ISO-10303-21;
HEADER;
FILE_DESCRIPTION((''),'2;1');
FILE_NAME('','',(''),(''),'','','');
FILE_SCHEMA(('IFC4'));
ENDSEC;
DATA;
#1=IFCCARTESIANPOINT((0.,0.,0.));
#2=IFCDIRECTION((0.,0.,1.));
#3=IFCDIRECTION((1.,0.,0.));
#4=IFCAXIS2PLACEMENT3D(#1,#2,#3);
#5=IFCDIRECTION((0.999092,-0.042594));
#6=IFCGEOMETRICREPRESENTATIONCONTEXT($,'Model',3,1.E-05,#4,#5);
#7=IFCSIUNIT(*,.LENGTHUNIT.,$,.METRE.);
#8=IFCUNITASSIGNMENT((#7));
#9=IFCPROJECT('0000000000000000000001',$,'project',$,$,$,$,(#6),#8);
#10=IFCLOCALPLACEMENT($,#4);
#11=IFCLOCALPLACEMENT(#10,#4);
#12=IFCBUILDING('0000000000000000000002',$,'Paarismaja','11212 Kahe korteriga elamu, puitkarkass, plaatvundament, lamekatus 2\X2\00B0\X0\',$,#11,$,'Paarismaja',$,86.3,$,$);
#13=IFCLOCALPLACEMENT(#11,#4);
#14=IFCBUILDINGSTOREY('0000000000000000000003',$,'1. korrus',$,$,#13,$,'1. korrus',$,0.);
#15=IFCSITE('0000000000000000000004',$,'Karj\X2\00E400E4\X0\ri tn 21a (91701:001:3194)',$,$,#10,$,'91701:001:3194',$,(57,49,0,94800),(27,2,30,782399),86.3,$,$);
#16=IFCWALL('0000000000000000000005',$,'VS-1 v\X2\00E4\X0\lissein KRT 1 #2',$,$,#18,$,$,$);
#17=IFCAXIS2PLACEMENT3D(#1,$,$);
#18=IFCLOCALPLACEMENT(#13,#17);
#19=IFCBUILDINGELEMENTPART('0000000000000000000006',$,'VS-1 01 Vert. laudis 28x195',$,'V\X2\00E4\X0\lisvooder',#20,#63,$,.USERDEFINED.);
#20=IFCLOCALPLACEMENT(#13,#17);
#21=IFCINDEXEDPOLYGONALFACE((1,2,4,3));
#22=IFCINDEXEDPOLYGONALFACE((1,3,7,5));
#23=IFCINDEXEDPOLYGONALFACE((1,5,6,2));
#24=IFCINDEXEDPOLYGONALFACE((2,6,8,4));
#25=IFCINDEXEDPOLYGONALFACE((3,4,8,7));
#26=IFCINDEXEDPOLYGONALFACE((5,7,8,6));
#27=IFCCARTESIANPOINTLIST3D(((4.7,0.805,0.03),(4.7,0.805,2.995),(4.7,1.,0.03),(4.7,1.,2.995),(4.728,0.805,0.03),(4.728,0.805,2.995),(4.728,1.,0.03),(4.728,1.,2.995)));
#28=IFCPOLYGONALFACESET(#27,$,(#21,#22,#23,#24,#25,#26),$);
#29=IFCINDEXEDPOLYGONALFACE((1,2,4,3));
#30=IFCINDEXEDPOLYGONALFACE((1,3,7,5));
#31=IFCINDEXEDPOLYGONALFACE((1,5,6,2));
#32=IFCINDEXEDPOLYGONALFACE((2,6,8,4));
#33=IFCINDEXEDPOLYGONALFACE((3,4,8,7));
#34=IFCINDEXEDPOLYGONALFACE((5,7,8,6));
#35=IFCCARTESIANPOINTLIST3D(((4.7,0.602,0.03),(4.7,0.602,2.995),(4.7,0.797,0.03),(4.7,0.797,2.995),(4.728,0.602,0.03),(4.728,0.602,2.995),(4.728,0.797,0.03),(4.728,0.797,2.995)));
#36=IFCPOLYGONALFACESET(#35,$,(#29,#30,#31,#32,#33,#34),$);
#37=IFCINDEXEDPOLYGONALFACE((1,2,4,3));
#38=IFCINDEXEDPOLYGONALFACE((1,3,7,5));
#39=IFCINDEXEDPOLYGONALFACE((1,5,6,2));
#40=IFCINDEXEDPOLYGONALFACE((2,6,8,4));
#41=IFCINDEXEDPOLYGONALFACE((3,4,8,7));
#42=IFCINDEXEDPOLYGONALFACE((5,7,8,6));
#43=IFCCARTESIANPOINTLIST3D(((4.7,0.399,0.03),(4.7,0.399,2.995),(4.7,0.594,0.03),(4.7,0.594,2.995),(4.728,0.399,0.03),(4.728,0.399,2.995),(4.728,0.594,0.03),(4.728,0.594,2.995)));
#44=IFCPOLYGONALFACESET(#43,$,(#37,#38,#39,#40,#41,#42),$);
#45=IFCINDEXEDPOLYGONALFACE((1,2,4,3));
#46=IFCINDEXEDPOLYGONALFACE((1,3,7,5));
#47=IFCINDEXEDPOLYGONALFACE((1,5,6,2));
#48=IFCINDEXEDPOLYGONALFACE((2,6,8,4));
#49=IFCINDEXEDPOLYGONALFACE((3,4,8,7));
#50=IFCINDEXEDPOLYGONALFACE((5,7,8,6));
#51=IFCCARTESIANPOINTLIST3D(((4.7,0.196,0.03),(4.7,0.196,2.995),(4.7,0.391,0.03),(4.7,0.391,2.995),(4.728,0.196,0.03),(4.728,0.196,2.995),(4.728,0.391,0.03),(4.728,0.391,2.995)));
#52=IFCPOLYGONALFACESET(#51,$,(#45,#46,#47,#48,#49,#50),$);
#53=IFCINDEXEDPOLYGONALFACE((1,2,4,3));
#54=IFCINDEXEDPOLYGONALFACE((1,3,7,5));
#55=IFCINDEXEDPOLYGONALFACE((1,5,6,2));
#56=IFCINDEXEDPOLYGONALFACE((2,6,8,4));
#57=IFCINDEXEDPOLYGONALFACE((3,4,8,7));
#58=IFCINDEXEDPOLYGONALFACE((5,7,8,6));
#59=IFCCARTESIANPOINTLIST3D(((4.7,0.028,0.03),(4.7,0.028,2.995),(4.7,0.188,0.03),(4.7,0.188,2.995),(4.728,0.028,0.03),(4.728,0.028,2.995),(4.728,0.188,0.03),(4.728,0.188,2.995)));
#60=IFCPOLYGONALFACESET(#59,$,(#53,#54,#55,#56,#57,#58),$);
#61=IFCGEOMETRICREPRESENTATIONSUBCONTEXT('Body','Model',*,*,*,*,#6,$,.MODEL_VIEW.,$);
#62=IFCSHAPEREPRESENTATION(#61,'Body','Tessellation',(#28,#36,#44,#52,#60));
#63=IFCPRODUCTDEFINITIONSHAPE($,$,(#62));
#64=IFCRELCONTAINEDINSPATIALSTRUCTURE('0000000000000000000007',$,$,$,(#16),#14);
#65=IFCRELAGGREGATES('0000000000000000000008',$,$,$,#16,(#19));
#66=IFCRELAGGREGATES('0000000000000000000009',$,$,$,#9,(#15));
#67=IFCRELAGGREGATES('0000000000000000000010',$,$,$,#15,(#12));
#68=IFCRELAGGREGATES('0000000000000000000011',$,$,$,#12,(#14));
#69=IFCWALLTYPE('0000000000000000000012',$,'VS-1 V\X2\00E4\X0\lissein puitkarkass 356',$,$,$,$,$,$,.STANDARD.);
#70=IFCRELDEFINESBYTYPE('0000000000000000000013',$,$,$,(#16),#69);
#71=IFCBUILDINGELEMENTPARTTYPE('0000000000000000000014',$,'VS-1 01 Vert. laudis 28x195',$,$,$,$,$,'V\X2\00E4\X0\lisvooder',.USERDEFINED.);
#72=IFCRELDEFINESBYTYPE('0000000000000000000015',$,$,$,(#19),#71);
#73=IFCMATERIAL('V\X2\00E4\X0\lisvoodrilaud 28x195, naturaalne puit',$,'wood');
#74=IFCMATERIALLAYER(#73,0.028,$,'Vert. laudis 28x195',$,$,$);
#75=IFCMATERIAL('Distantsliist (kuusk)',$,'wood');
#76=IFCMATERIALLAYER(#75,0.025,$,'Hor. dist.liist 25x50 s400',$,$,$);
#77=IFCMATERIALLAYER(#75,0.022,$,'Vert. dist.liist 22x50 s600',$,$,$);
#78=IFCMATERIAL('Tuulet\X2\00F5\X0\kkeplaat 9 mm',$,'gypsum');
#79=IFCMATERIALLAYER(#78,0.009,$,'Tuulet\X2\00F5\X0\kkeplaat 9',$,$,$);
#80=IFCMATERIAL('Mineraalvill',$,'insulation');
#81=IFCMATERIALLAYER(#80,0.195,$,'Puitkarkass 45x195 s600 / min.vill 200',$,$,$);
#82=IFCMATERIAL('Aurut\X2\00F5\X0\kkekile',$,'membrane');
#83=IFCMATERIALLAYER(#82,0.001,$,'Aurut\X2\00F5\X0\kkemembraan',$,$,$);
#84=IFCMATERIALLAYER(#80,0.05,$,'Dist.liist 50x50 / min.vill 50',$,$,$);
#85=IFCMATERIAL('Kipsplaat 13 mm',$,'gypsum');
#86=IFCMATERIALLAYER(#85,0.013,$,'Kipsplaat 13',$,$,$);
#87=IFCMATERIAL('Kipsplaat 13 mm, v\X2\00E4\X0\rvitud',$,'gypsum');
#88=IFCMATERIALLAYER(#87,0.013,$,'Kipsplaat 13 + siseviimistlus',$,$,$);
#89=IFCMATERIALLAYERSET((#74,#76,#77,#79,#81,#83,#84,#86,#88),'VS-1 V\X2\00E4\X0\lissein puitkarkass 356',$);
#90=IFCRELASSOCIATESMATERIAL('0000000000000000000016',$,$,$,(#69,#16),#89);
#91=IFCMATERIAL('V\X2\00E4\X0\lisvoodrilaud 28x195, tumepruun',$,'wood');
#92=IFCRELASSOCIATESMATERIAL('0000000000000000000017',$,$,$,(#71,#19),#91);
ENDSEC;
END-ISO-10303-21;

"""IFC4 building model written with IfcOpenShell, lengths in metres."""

from ifc_helpers import new_model, si_unit, direction, frame, origin_with_axes, place, context, subcontext, project, spatial, indexed_curve, outline, extrude, material, layer, layer_set, layer_usage, type_object, element, aggregate, save


model = new_model("IFC4")

# Units and contexts
model_context = context("Model", 3, precision=1e-05, world=origin_with_axes(), true_north=direction((0.999092, -0.042594)))
body_context = subcontext(model_context, "Body", "Model", "MODEL_VIEW")
ifc_project = project(units=[si_unit("LENGTHUNIT", "METRE")], contexts=[model_context])

# Site, building, storey
site_placement = place(None, origin_with_axes())
site = spatial("IfcSite", under=ifc_project, at=site_placement, Name="Karjääri tn 21a (91701:001:3194)", LongName="91701:001:3194", RefLatitude=(57, 49, 0, 94800), RefLongitude=(27, 2, 30, 782399), RefElevation=86.3)
building_placement = place(site_placement, origin_with_axes())
building = spatial("IfcBuilding", under=site, at=building_placement, Name="Paarismaja", Description="11212 Kahe korteriga elamu, puitkarkass, plaatvundament, lamekatus 2°", LongName="Paarismaja", ElevationOfRefHeight=86.3)
storey_placement = place(building_placement, origin_with_axes())
storey = spatial("IfcBuildingStorey", under=building, at=storey_placement, Name="1. korrus", LongName="1. korrus", Elevation=0.0)

# Wall
ifc_material_1 = material(Name="Välisvoodrilaud 28x195, naturaalne puit", Category="wood")
ifc_layer_1 = layer(ifc_material_1, 0.028, Name="Vert. laudis 28x195")
ifc_material_2 = material(Name="Distantsliist (kuusk)", Category="wood")
ifc_layer_2 = layer(ifc_material_2, 0.025, Name="Hor. dist.liist 25x50 s400")
ifc_layer_3 = layer(ifc_material_2, 0.022, Name="Vert. dist.liist 22x50 s600")
ifc_material_3 = material(Name="Tuuletõkkeplaat 9 mm", Category="gypsum")
ifc_layer_4 = layer(ifc_material_3, 0.009, Name="Tuuletõkkeplaat 9")
ifc_material_4 = material(Name="Mineraalvill", Category="insulation")
ifc_layer_5 = layer(ifc_material_4, 0.195, Name="Puitkarkass 45x195 s600 / min.vill 200")
ifc_material_5 = material(Name="Aurutõkkekile", Category="membrane")
ifc_layer_6 = layer(ifc_material_5, 0.001, Name="Aurutõkkemembraan")
ifc_layer_7 = layer(ifc_material_4, 0.05, Name="Dist.liist 50x50 / min.vill 50")
ifc_material_6 = material(Name="Kipsplaat 13 mm", Category="gypsum")
ifc_layer_8 = layer(ifc_material_6, 0.013, Name="Kipsplaat 13")
ifc_material_7 = material(Name="Kipsplaat 13 mm, värvitud", Category="gypsum")
ifc_layer_9 = layer(ifc_material_7, 0.013, Name="Kipsplaat 13 + siseviimistlus")
ifc_layer_set_1 = layer_set([ifc_layer_1, ifc_layer_2, ifc_layer_3, ifc_layer_4, ifc_layer_5, ifc_layer_6, ifc_layer_7, ifc_layer_8, ifc_layer_9], Name="VS-1 Välissein puitkarkass 356")
ifc_layer_usage_1 = layer_usage(ifc_layer_set_1, "AXIS2", "POSITIVE", 0.0)
wall_type = type_object("IfcWallType", Name="VS-1 Välissein puitkarkass 356", PredefinedType="STANDARD", material=ifc_layer_set_1)
wall_placement = place(storey_placement, frame((4.7, 1.0, 0.0), z_axis=(0.0, 0.0, 1.0), x_axis=(0.0, -1.0, 0.0)))
wall = element("IfcWall", 1, at=wall_placement, inside=storey, type_object=wall_type, material=ifc_layer_usage_1, Name="VS-1 välissein KRT 1 #2")

# Building element part
ifc_material_8 = material(Name="Välisvoodrilaud 28x195, tumepruun", Category="wood")
building_element_part_type_1 = type_object("IfcBuildingElementPartType", Name="VS-1 01 Vert. laudis 28x195", ElementType="Välisvooder", PredefinedType="USERDEFINED", material=ifc_material_8)
building_element_part_1_placement = place(wall_placement, origin_with_axes())
building_element_part_1 = element("IfcBuildingElementPart", 2, at=building_element_part_1_placement, type_object=building_element_part_type_1, material=ifc_material_8, Name="VS-1 01 Vert. laudis 28x195", ObjectType="Välisvooder", PredefinedType="USERDEFINED", context=body_context, shape_type="SweptSolid", body=[
    extrude(outline(indexed_curve([(0.195, 0.03), (0.0, 0.03), (0.0, 2.995), (0.195, 2.995), (0.195, 0.03)], self_intersect=False)), frame((0.0, 0.028, 0.0), z_axis=(0.0, -1.0, 0.0), x_axis=(1.0, 0.0, 0.0)), (0.0, 0.0, 1.0), 0.028),
    extrude(outline(indexed_curve([(0.398, 0.03), (0.203, 0.03), (0.203, 2.995), (0.398, 2.995), (0.398, 0.03)], self_intersect=False)), frame((0.0, 0.028, 0.0), z_axis=(0.0, -1.0, 0.0), x_axis=(1.0, 0.0, 0.0)), (0.0, 0.0, 1.0), 0.028),
    extrude(outline(indexed_curve([(0.601, 0.03), (0.406, 0.03), (0.406, 2.995), (0.601, 2.995), (0.601, 0.03)], self_intersect=False)), frame((0.0, 0.028, 0.0), z_axis=(0.0, -1.0, 0.0), x_axis=(1.0, 0.0, 0.0)), (0.0, 0.0, 1.0), 0.028),
    extrude(outline(indexed_curve([(0.804, 0.03), (0.609, 0.03), (0.609, 2.995), (0.804, 2.995), (0.804, 0.03)], self_intersect=False)), frame((0.0, 0.028, 0.0), z_axis=(0.0, -1.0, 0.0), x_axis=(1.0, 0.0, 0.0)), (0.0, 0.0, 1.0), 0.028),
    extrude(outline(indexed_curve([(0.972, 0.03), (0.812, 0.03), (0.812, 2.995), (0.972, 2.995), (0.972, 0.03)], self_intersect=False)), frame((0.0, 0.028, 0.0), z_axis=(0.0, -1.0, 0.0), x_axis=(1.0, 0.0, 0.0)), (0.0, 0.0, 1.0), 0.028),
])
aggregate(wall, [building_element_part_1])

save(model, "model.ifc")
